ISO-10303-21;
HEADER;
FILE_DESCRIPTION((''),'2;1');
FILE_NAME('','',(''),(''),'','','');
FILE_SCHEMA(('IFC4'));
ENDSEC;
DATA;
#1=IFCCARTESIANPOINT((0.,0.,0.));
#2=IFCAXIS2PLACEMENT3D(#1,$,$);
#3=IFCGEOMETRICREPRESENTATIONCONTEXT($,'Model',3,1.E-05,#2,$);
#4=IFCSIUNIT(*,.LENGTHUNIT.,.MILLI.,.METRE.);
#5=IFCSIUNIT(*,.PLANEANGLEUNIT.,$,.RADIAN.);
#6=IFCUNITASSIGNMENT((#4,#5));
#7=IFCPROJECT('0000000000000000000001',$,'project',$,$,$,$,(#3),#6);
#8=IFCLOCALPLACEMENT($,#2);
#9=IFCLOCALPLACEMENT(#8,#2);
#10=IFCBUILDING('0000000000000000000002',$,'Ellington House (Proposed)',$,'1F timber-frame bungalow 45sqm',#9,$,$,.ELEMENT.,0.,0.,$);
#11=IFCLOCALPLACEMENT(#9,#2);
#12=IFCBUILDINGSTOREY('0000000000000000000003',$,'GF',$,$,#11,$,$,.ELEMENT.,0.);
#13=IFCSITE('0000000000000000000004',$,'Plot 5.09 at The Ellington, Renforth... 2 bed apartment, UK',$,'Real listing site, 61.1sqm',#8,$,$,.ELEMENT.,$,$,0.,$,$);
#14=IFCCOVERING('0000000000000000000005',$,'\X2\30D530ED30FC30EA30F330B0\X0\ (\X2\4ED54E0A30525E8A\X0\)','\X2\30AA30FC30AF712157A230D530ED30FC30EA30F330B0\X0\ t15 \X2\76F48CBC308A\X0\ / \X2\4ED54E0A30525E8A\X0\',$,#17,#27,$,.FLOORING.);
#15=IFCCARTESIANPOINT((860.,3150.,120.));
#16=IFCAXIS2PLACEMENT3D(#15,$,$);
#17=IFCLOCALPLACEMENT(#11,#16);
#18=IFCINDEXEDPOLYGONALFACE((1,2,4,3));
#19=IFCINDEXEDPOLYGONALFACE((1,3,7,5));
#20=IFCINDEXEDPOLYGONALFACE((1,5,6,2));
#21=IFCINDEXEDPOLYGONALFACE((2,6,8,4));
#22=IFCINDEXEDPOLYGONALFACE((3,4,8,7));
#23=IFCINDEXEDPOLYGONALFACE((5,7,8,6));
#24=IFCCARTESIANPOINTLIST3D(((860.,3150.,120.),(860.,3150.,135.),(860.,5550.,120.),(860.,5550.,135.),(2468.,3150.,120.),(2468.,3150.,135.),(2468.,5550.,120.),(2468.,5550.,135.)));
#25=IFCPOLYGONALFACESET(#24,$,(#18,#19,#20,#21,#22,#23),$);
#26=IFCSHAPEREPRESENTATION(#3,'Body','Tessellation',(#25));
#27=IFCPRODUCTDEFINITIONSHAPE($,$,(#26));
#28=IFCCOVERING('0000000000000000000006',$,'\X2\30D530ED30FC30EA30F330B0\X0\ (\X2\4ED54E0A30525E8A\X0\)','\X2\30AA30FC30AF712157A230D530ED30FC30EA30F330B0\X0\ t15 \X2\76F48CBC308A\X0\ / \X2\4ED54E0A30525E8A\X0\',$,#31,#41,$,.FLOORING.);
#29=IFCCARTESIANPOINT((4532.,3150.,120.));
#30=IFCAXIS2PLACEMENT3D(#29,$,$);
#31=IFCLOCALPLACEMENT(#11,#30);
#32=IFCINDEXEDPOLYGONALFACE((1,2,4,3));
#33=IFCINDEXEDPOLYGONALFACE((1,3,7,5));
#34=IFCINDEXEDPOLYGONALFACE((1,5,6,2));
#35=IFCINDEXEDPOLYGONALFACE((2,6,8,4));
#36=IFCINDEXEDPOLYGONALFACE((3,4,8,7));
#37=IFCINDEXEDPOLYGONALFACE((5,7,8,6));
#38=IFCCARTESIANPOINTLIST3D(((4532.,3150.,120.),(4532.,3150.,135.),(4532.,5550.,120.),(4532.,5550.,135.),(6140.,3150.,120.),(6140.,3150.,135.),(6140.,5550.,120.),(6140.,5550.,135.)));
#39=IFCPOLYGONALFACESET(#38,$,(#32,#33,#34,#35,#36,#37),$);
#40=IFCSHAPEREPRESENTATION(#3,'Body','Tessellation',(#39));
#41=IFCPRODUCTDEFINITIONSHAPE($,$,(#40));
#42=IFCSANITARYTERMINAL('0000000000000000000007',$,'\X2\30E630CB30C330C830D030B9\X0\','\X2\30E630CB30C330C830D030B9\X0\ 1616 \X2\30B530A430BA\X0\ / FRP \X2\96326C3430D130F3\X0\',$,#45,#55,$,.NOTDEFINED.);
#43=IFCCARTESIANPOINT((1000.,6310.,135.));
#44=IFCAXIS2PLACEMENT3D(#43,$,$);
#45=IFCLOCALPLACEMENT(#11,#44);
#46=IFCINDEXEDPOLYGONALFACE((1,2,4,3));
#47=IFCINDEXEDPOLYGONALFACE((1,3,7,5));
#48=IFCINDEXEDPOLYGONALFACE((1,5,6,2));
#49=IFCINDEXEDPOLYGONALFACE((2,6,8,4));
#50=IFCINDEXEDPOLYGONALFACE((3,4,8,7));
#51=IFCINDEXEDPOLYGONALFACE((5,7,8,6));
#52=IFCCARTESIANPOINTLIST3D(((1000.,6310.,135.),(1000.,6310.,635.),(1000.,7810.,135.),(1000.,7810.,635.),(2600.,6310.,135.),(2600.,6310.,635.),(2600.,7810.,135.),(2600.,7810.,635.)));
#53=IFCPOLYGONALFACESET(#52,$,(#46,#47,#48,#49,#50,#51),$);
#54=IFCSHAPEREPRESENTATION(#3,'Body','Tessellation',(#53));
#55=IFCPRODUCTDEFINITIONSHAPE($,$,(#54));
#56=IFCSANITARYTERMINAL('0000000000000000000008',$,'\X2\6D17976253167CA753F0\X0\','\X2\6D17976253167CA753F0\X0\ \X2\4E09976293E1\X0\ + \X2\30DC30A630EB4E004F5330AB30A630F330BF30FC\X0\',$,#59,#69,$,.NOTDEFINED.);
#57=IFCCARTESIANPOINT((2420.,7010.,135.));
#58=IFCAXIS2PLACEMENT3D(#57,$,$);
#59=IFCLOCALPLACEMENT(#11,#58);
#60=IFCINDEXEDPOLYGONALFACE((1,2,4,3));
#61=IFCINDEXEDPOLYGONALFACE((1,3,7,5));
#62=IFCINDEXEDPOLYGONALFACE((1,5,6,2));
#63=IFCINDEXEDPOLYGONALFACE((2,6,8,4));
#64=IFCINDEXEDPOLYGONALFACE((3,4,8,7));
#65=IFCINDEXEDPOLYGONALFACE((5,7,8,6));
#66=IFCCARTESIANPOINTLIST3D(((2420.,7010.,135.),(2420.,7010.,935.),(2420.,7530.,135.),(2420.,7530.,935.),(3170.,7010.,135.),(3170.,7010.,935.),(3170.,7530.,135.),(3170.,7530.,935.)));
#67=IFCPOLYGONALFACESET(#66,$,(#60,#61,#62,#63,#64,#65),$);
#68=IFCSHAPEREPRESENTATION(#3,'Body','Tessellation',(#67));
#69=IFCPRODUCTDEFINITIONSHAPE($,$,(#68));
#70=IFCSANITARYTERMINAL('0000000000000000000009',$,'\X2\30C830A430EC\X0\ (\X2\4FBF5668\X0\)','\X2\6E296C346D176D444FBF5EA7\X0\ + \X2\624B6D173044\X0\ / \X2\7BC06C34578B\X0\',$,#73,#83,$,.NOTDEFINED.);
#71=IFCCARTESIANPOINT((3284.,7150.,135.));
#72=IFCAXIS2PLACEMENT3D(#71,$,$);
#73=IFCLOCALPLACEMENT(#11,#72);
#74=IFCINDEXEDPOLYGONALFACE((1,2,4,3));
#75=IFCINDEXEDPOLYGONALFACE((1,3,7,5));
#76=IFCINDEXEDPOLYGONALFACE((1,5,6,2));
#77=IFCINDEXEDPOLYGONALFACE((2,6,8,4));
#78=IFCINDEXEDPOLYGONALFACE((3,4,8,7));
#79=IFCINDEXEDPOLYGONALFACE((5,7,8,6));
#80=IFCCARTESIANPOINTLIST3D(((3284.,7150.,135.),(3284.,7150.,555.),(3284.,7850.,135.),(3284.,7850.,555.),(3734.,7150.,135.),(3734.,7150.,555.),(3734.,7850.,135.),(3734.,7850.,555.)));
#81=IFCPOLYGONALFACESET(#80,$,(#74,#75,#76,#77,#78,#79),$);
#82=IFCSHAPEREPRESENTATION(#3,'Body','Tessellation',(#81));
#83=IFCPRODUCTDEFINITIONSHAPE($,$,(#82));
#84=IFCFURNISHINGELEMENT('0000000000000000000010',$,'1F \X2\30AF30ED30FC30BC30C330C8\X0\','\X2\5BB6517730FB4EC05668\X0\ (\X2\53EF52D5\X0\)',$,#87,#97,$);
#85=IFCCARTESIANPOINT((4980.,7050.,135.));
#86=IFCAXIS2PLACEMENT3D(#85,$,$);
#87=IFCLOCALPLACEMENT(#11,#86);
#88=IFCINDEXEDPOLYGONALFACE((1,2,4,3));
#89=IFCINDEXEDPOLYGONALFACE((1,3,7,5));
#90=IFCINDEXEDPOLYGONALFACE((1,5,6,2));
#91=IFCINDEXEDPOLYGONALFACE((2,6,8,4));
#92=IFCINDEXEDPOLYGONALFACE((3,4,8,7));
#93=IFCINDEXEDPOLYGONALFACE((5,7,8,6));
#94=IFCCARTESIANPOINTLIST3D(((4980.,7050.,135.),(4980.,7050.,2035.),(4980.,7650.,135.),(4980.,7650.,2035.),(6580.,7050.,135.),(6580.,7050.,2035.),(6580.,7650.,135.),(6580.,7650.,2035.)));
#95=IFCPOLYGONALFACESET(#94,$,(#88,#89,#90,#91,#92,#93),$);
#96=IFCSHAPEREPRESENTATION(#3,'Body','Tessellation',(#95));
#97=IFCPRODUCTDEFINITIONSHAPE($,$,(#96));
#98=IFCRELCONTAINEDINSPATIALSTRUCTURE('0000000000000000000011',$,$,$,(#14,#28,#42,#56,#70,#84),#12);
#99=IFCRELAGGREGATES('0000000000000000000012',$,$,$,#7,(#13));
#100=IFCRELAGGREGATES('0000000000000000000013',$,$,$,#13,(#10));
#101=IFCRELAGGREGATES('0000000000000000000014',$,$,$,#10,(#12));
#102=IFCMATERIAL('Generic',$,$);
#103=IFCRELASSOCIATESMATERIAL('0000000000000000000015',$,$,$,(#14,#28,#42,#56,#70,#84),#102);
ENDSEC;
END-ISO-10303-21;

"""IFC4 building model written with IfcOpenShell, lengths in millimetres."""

from ifc_helpers import new_model, si_unit, frame, frame_2d, origin, place, context, project, spatial, rectangle, extrude, material, element, save


model = new_model("IFC4")

# Units and contexts
model_context = context("Model", 3, precision=1e-05, world=origin())
ifc_project = project(units=[si_unit("LENGTHUNIT", "METRE", prefix="MILLI"), si_unit("PLANEANGLEUNIT", "RADIAN")], contexts=[model_context])

# Site, building, storey
site_placement = place(None, origin())
site = spatial("IfcSite", under=ifc_project, at=site_placement, Name="Plot 5.09 at The Ellington, Renforth... 2 bed apartment, UK", ObjectType="Real listing site, 61.1sqm", CompositionType="ELEMENT", RefElevation=0.0)
building_placement = place(site_placement, origin())
building = spatial("IfcBuilding", under=site, at=building_placement, Name="Ellington House (Proposed)", ObjectType="1F timber-frame bungalow 45sqm", CompositionType="ELEMENT", ElevationOfRefHeight=0.0, ElevationOfTerrain=0.0)
storey_placement = place(building_placement, origin())
storey = spatial("IfcBuildingStorey", under=building, at=storey_placement, Name="GF", CompositionType="ELEMENT", Elevation=0.0)

# Coverings
ifc_material_1 = material(Name="Generic")
covering_1_placement = place(storey_placement, frame((860.0, 3150.0, 120.0)))
element("IfcCovering", 1, at=covering_1_placement, inside=storey, material=ifc_material_1, Name="フローリング (仕上げ床)", Description="オーク無垢フローリング t15 直貼り / 仕上げ床", PredefinedType="FLOORING", context=model_context, shape_type="SweptSolid", body=[
    extrude(rectangle(XDim=1608.0, YDim=2400.0, at=frame_2d((804.0, 1200.0))), frame((860.0, 3150.0, 120.0)), (0.0, 0.0, 1.0), 15.0),
])
covering_2_placement = place(storey_placement, frame((4532.0, 3150.0, 120.0)))
element("IfcCovering", 2, at=covering_2_placement, inside=storey, material=ifc_material_1, Name="フローリング (仕上げ床)", Description="オーク無垢フローリング t15 直貼り / 仕上げ床", PredefinedType="FLOORING", context=model_context, shape_type="SweptSolid", body=[
    extrude(rectangle(XDim=1608.0, YDim=2400.0, at=frame_2d((804.0, 1200.0))), frame((4532.0, 3150.0, 120.0)), (0.0, 0.0, 1.0), 15.0),
])

# Sanitary terminals
sanitary_terminal_1_placement = place(storey_placement, frame((1000.0, 6310.0, 135.0)))
element("IfcSanitaryTerminal", 3, at=sanitary_terminal_1_placement, inside=storey, material=ifc_material_1, Name="ユニットバス", Description="ユニットバス 1616 サイズ / FRP 防水パン", PredefinedType="NOTDEFINED", context=model_context, shape_type="SweptSolid", body=[
    extrude(rectangle(XDim=1600.0, YDim=1500.0, at=frame_2d((800.0, 750.0))), frame((1000.0, 6310.0, 135.0)), (0.0, 0.0, 1.0), 500.0),
])
sanitary_terminal_2_placement = place(storey_placement, frame((2420.0, 7010.0, 135.0)))
element("IfcSanitaryTerminal", 4, at=sanitary_terminal_2_placement, inside=storey, material=ifc_material_1, Name="洗面化粧台", Description="洗面化粧台 三面鏡 + ボウル一体カウンター", PredefinedType="NOTDEFINED", context=model_context, shape_type="SweptSolid", body=[
    extrude(rectangle(XDim=750.0, YDim=520.0, at=frame_2d((375.0, 260.0))), frame((2420.0, 7010.0, 135.0)), (0.0, 0.0, 1.0), 800.0),
])
sanitary_terminal_3_placement = place(storey_placement, frame((3284.0, 7150.0, 135.0)))
element("IfcSanitaryTerminal", 5, at=sanitary_terminal_3_placement, inside=storey, material=ifc_material_1, Name="トイレ (便器)", Description="温水洗浄便座 + 手洗い / 節水型", PredefinedType="NOTDEFINED", context=model_context, shape_type="SweptSolid", body=[
    extrude(rectangle(XDim=450.0, YDim=700.0, at=frame_2d((225.0, 350.0))), frame((3284.0, 7150.0, 135.0)), (0.0, 0.0, 1.0), 420.0),
])

# Furnishing element
furnishing_placement = place(storey_placement, frame((4980.0, 7050.0, 135.0)))
element("IfcFurnishingElement", 6, at=furnishing_placement, inside=storey, material=ifc_material_1, Name="1F クローゼット", Description="家具・什器 (可動)", context=model_context, shape_type="SweptSolid", body=[
    extrude(rectangle(XDim=1600.0, YDim=600.0, at=frame_2d((800.0, 300.0))), frame((4980.0, 7050.0, 135.0)), (0.0, 0.0, 1.0), 1900.0),
])

save(model, "model.ifc")
